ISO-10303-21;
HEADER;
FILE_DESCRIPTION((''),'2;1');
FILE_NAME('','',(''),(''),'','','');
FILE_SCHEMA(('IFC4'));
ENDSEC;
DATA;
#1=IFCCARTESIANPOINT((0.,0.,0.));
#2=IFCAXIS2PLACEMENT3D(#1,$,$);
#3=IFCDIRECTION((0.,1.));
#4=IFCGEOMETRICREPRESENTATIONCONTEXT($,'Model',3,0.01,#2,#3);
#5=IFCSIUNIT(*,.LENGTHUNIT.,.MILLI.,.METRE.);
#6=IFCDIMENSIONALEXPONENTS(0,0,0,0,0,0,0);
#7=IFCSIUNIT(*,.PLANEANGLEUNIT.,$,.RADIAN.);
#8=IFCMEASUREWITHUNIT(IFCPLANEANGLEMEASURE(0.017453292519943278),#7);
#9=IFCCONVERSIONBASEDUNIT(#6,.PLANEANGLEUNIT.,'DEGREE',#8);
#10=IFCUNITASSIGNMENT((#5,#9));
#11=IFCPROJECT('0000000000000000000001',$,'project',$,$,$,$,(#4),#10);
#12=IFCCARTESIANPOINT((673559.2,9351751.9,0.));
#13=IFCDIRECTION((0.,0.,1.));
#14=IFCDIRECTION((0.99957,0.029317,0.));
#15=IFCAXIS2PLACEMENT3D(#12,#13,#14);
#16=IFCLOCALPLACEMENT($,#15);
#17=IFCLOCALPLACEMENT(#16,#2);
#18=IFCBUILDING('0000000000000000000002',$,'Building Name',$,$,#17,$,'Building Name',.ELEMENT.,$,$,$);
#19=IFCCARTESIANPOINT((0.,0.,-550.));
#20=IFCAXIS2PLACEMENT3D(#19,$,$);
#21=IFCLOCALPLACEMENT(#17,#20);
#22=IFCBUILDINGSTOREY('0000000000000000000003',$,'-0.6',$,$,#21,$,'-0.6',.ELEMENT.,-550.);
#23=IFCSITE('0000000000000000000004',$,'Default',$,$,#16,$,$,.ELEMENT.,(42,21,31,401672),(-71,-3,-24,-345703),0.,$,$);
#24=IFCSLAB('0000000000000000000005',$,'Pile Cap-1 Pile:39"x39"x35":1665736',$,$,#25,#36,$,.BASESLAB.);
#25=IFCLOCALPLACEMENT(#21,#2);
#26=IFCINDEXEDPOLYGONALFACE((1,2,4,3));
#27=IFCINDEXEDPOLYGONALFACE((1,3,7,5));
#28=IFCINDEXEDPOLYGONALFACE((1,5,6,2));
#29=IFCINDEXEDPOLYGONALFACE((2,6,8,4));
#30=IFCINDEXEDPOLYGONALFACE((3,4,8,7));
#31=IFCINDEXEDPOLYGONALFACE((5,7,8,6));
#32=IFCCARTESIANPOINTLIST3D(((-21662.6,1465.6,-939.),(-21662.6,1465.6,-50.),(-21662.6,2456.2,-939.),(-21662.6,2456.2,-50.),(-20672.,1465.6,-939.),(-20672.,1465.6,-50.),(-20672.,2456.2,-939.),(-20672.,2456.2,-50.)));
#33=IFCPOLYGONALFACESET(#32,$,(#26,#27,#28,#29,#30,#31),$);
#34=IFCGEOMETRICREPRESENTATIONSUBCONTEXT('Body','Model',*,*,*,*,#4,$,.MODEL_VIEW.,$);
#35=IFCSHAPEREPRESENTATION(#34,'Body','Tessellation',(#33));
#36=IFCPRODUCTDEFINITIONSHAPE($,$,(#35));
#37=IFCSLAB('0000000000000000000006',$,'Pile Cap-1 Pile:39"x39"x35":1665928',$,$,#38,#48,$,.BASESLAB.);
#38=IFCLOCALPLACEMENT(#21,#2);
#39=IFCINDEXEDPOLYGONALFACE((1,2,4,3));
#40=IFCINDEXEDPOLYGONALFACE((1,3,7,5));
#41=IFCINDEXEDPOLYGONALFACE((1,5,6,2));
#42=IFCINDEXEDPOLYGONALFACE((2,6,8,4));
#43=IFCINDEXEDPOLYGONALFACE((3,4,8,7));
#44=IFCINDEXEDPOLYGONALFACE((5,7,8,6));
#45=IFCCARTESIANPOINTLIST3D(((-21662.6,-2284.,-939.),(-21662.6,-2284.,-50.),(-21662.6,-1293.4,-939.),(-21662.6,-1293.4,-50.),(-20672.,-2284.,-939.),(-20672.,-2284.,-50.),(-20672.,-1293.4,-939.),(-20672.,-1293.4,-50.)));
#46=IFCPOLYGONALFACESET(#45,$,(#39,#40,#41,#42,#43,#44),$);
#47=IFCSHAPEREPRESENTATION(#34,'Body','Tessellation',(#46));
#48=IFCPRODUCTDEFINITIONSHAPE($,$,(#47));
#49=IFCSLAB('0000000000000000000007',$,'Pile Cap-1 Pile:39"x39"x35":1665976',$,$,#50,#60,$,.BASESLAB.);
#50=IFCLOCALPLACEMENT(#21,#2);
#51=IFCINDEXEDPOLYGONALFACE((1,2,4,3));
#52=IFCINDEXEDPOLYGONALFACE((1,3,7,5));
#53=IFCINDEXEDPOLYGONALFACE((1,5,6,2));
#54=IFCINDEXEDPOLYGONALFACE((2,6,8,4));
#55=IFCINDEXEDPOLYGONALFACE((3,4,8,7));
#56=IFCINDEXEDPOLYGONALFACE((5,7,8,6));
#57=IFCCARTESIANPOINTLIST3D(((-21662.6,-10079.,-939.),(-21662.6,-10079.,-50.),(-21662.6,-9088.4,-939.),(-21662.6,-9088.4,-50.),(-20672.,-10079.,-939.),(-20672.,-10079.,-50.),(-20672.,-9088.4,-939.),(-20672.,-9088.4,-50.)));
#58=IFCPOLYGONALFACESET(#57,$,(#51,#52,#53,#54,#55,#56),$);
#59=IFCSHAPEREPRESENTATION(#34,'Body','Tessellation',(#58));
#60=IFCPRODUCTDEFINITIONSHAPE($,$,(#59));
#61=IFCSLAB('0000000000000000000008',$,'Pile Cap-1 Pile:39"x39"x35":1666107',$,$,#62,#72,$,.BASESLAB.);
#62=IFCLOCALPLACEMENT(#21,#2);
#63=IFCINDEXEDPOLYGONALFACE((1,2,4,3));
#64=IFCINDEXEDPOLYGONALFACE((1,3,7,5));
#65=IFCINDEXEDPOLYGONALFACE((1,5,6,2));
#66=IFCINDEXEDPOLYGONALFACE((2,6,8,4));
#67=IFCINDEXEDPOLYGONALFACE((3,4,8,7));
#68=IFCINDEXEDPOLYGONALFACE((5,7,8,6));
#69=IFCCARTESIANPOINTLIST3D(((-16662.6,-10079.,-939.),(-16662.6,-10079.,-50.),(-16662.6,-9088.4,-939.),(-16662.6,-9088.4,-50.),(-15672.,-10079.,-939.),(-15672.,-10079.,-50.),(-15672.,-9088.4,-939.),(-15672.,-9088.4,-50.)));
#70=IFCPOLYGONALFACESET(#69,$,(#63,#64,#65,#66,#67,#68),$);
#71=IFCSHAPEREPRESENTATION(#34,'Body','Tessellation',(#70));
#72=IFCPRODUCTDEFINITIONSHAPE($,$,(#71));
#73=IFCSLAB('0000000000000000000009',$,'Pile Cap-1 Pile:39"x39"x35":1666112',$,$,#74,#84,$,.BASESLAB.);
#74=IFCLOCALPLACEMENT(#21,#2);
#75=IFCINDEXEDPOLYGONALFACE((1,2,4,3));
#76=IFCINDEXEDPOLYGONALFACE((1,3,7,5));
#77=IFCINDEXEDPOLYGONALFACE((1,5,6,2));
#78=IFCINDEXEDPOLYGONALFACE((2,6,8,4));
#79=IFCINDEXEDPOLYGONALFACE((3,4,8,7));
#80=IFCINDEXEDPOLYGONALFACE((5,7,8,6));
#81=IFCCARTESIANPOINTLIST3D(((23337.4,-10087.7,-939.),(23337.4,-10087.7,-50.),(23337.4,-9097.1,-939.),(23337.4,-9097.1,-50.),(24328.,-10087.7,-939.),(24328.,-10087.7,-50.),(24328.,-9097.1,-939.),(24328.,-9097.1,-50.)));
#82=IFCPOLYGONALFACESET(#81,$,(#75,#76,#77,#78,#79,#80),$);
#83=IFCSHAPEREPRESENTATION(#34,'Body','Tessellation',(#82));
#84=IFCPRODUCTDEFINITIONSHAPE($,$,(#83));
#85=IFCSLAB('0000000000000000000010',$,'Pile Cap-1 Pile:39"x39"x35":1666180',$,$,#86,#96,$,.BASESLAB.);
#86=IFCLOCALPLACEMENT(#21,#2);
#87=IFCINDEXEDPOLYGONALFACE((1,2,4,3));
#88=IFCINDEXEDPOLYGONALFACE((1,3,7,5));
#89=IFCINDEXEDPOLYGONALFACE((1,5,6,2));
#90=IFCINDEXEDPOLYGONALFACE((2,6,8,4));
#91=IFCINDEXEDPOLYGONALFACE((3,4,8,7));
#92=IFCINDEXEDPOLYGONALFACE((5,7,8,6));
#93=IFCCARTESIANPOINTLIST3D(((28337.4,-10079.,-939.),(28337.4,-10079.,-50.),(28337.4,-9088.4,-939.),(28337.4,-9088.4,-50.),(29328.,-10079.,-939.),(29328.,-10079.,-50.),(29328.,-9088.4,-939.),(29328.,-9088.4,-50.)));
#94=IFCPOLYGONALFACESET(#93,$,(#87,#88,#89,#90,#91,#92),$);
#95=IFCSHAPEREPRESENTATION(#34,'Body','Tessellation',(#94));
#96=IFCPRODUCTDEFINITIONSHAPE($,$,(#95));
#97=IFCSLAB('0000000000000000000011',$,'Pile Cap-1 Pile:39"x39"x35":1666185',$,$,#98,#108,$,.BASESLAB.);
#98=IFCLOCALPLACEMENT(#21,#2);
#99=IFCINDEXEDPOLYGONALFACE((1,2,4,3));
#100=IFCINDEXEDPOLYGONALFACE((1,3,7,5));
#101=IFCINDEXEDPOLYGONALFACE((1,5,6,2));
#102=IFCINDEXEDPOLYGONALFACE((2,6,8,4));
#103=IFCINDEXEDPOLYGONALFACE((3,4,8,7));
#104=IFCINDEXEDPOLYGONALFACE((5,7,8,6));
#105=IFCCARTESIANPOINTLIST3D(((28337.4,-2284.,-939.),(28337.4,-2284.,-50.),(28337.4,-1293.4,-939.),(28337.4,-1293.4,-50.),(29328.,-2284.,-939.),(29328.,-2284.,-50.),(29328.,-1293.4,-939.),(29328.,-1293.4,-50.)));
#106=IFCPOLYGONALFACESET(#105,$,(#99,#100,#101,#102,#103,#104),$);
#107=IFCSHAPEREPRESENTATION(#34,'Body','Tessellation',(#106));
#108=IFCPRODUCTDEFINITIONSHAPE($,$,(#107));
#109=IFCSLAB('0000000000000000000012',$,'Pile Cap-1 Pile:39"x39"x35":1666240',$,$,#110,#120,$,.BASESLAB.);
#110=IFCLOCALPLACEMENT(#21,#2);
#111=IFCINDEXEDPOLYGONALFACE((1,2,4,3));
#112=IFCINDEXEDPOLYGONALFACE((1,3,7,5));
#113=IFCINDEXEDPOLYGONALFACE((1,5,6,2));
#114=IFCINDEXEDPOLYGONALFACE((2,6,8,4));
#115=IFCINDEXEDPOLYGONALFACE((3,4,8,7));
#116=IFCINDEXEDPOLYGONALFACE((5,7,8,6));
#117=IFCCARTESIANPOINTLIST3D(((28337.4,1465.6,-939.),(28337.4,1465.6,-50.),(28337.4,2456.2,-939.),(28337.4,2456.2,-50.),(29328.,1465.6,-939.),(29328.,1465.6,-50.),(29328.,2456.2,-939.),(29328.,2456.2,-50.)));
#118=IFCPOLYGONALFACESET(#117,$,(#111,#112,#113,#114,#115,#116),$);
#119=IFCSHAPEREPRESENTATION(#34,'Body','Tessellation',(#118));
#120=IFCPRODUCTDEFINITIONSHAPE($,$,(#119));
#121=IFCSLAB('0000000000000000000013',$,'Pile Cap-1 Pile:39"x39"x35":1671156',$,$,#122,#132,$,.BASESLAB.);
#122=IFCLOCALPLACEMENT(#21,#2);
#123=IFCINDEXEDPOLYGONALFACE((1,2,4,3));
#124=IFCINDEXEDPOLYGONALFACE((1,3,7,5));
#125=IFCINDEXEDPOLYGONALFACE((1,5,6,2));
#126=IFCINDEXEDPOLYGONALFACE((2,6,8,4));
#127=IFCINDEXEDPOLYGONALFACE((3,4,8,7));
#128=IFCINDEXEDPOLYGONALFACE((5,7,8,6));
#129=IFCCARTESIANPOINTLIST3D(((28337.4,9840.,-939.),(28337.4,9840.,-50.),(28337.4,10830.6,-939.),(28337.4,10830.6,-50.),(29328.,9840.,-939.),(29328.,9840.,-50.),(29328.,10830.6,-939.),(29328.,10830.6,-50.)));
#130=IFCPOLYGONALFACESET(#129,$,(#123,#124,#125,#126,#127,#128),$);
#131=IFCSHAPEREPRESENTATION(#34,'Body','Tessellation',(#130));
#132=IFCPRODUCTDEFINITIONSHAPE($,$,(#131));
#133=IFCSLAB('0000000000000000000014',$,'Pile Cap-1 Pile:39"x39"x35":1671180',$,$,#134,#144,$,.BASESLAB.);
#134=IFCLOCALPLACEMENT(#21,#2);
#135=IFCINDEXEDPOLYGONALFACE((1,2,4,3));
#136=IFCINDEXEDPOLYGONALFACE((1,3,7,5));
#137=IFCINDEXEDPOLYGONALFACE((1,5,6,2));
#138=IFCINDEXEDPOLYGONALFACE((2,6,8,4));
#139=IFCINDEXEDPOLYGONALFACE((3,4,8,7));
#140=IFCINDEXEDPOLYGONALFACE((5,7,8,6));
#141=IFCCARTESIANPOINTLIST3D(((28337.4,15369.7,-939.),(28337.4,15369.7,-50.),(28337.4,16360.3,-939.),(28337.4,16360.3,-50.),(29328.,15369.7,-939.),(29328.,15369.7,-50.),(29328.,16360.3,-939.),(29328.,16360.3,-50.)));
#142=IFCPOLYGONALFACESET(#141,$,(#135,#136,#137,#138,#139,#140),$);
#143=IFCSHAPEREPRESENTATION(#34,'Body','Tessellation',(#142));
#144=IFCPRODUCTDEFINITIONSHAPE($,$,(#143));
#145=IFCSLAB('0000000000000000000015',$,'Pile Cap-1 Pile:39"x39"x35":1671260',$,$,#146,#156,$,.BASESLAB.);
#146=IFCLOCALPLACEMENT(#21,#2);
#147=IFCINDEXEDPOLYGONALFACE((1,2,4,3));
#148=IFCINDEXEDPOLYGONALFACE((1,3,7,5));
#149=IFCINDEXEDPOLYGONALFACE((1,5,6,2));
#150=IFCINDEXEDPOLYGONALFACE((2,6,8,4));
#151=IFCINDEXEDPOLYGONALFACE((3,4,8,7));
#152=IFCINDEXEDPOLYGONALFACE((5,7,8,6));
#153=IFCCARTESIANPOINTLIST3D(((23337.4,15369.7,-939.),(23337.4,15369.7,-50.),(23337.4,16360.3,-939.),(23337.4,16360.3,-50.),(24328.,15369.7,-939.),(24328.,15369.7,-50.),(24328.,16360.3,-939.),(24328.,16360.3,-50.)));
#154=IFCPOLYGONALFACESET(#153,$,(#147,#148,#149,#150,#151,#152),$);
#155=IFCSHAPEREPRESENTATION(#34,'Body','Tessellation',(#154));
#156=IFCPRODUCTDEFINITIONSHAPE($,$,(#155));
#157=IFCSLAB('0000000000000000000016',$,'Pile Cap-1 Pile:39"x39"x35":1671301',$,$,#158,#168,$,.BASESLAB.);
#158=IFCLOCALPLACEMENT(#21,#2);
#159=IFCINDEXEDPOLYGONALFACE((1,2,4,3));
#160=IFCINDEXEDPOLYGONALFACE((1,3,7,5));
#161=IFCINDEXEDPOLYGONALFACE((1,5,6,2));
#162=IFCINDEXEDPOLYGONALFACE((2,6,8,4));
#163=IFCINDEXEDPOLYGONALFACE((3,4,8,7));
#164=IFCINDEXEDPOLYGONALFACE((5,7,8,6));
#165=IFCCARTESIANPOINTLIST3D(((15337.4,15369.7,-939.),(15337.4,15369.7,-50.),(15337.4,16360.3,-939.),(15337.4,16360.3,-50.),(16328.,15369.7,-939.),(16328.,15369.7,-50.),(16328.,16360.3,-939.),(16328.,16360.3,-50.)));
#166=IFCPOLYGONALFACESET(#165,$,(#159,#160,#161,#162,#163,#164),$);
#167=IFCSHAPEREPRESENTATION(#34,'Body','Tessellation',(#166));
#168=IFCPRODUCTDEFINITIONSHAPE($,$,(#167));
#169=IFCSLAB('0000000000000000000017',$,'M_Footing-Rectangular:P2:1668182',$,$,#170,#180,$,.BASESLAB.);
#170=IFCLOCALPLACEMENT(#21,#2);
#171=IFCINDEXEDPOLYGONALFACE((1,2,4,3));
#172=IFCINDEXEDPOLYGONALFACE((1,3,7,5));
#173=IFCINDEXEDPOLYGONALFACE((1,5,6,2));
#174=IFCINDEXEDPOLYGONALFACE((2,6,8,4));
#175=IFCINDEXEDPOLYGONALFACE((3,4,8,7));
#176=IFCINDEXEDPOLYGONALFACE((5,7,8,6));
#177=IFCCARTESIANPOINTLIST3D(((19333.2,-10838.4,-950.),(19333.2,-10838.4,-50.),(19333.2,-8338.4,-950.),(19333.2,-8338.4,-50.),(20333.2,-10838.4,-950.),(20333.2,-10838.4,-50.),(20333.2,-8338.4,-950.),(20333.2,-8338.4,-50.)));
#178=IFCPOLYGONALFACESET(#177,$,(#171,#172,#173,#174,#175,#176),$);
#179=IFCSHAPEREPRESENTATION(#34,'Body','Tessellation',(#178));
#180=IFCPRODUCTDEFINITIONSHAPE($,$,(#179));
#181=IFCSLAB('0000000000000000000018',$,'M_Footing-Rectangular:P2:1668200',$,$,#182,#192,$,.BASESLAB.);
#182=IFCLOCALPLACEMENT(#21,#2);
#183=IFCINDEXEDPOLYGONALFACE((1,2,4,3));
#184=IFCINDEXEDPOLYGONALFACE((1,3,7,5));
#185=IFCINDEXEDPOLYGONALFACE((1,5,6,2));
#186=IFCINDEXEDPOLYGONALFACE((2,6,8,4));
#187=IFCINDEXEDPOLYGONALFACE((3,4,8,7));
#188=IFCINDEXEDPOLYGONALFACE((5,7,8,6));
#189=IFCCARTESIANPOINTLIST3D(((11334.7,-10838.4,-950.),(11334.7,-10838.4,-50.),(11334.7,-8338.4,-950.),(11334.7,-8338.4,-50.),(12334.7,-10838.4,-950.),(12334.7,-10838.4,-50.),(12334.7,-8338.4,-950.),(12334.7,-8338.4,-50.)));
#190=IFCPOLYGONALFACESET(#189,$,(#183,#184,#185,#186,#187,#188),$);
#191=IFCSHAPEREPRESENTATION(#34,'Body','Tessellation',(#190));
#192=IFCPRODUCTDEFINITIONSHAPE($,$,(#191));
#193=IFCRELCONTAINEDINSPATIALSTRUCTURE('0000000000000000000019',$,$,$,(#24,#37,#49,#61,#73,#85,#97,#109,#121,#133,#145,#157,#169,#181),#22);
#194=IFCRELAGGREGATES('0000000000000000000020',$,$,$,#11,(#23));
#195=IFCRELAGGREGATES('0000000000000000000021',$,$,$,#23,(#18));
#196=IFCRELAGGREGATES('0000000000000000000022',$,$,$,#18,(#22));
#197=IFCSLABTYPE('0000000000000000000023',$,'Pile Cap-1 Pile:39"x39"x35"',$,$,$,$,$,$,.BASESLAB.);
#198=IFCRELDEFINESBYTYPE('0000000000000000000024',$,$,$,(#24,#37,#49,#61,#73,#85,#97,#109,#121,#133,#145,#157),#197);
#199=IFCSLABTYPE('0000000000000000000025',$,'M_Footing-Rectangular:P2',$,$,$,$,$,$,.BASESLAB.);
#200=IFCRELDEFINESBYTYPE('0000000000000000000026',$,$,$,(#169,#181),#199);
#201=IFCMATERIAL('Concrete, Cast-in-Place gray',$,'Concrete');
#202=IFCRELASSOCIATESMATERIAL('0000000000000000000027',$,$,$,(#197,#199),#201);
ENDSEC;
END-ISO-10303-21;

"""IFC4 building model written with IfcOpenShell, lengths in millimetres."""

from ifc_helpers import new_model, entity, si_unit, converted_unit, direction, frame, origin, place, context, subcontext, project, spatial, indexed_curve, outline, extrude, material, type_object, element, save


model = new_model("IFC4")

# Units and contexts
model_context = context("Model", 3, precision=0.01, world=origin(), true_north=direction((0.0, 1.0)))
body_context = subcontext(model_context, "Body", "Model", "MODEL_VIEW")
ifc_project = project(units=[si_unit("LENGTHUNIT", "METRE", prefix="MILLI"), converted_unit("PLANEANGLEUNIT", "DEGREE", entity("IfcPlaneAngleMeasure", 0.017453292519943278), si_unit("PLANEANGLEUNIT", "RADIAN"), dimensions=[0, 0, 0, 0, 0, 0, 0])], contexts=[model_context])

# Site, building, storey
site_placement = place(None, frame((673559.2, 9351751.9, 0.0), z_axis=(0.0, 0.0, 1.0), x_axis=(0.99957, 0.029317, 0.0)))
site = spatial("IfcSite", under=ifc_project, at=site_placement, Name="Default", CompositionType="ELEMENT", RefLatitude=(42, 21, 31, 401672), RefLongitude=(-71, -3, -24, -345703), RefElevation=0.0)
building_placement = place(site_placement, origin())
building = spatial("IfcBuilding", under=site, at=building_placement, Name="Building Name", LongName="Building Name", CompositionType="ELEMENT")
storey_placement = place(building_placement, frame((0.0, 0.0, -550.0)))
storey = spatial("IfcBuildingStorey", under=building, at=storey_placement, Name="-0.6", LongName="-0.6", CompositionType="ELEMENT", Elevation=-550.0)

# Shared definitions
ifc_material = material(Name="Concrete, Cast-in-Place gray", Category="Concrete")

# Slabs
slab_type_1 = type_object("IfcSlabType", Name="Pile Cap-1 Pile:39\"x39\"x35\"", PredefinedType="BASESLAB", material=ifc_material)
slab_1_placement = place(storey_placement, origin())
element("IfcSlab", 1, at=slab_1_placement, inside=storey, type_object=slab_type_1, Name="Pile Cap-1 Pile:39\"x39\"x35\":1665736", PredefinedType="BASESLAB", context=body_context, shape_type="SweptSolid", body=[
    extrude(outline(indexed_curve([(-495.3, -495.3), (495.3, -495.3), (495.3, 495.3), (-495.3, 495.3), (-495.3, -495.3)], self_intersect=False)), frame((-21167.3, 1960.9, -939.0)), (0.0, 0.0, 1.0), 889.0),
])
slab_2_placement = place(storey_placement, origin())
element("IfcSlab", 2, at=slab_2_placement, inside=storey, type_object=slab_type_1, Name="Pile Cap-1 Pile:39\"x39\"x35\":1665928", PredefinedType="BASESLAB", context=body_context, shape_type="SweptSolid", body=[
    extrude(outline(indexed_curve([(-495.3, -495.3), (495.3, -495.3), (495.3, 495.3), (-495.3, 495.3), (-495.3, -495.3)], self_intersect=False)), frame((-21167.3, -1788.7, -939.0)), (0.0, 0.0, 1.0), 889.0),
])
slab_3_placement = place(storey_placement, origin())
element("IfcSlab", 3, at=slab_3_placement, inside=storey, type_object=slab_type_1, Name="Pile Cap-1 Pile:39\"x39\"x35\":1665976", PredefinedType="BASESLAB", context=body_context, shape_type="SweptSolid", body=[
    extrude(outline(indexed_curve([(-495.3, -495.3), (495.3, -495.3), (495.3, 495.3), (-495.3, 495.3), (-495.3, -495.3)], self_intersect=False)), frame((-21167.3, -9583.7, -939.0)), (0.0, 0.0, 1.0), 889.0),
])
slab_4_placement = place(storey_placement, origin())
element("IfcSlab", 4, at=slab_4_placement, inside=storey, type_object=slab_type_1, Name="Pile Cap-1 Pile:39\"x39\"x35\":1666107", PredefinedType="BASESLAB", context=body_context, shape_type="SweptSolid", body=[
    extrude(outline(indexed_curve([(-495.3, -495.3), (495.3, -495.3), (495.3, 495.3), (-495.3, 495.3), (-495.3, -495.3)], self_intersect=False)), frame((-16167.3, -9583.7, -939.0)), (0.0, 0.0, 1.0), 889.0),
])
slab_5_placement = place(storey_placement, origin())
element("IfcSlab", 5, at=slab_5_placement, inside=storey, type_object=slab_type_1, Name="Pile Cap-1 Pile:39\"x39\"x35\":1666112", PredefinedType="BASESLAB", context=body_context, shape_type="SweptSolid", body=[
    extrude(outline(indexed_curve([(-495.3, -495.3), (495.3, -495.3), (495.3, 495.3), (-495.3, 495.3), (-495.3, -495.3)], self_intersect=False)), frame((23832.7, -9592.4, -939.0)), (0.0, 0.0, 1.0), 889.0),
])
slab_6_placement = place(storey_placement, origin())
element("IfcSlab", 6, at=slab_6_placement, inside=storey, type_object=slab_type_1, Name="Pile Cap-1 Pile:39\"x39\"x35\":1666180", PredefinedType="BASESLAB", context=body_context, shape_type="SweptSolid", body=[
    extrude(outline(indexed_curve([(-495.3, -495.3), (495.3, -495.3), (495.3, 495.3), (-495.3, 495.3), (-495.3, -495.3)], self_intersect=False)), frame((28832.7, -9583.7, -939.0)), (0.0, 0.0, 1.0), 889.0),
])
slab_7_placement = place(storey_placement, origin())
element("IfcSlab", 7, at=slab_7_placement, inside=storey, type_object=slab_type_1, Name="Pile Cap-1 Pile:39\"x39\"x35\":1666185", PredefinedType="BASESLAB", context=body_context, shape_type="SweptSolid", body=[
    extrude(outline(indexed_curve([(-495.3, -495.3), (495.3, -495.3), (495.3, 495.3), (-495.3, 495.3), (-495.3, -495.3)], self_intersect=False)), frame((28832.7, -1788.7, -939.0)), (0.0, 0.0, 1.0), 889.0),
])
slab_8_placement = place(storey_placement, origin())
element("IfcSlab", 8, at=slab_8_placement, inside=storey, type_object=slab_type_1, Name="Pile Cap-1 Pile:39\"x39\"x35\":1666240", PredefinedType="BASESLAB", context=body_context, shape_type="SweptSolid", body=[
    extrude(outline(indexed_curve([(-495.3, -495.3), (495.3, -495.3), (495.3, 495.3), (-495.3, 495.3), (-495.3, -495.3)], self_intersect=False)), frame((28832.7, 1960.9, -939.0)), (0.0, 0.0, 1.0), 889.0),
])
slab_9_placement = place(storey_placement, origin())
element("IfcSlab", 9, at=slab_9_placement, inside=storey, type_object=slab_type_1, Name="Pile Cap-1 Pile:39\"x39\"x35\":1671156", PredefinedType="BASESLAB", context=body_context, shape_type="SweptSolid", body=[
    extrude(outline(indexed_curve([(-495.3, -495.3), (495.3, -495.3), (495.3, 495.3), (-495.3, 495.3), (-495.3, -495.3)], self_intersect=False)), frame((28832.7, 10335.3, -939.0)), (0.0, 0.0, 1.0), 889.0),
])
slab_10_placement = place(storey_placement, origin())
element("IfcSlab", 10, at=slab_10_placement, inside=storey, type_object=slab_type_1, Name="Pile Cap-1 Pile:39\"x39\"x35\":1671180", PredefinedType="BASESLAB", context=body_context, shape_type="SweptSolid", body=[
    extrude(outline(indexed_curve([(-495.3, -495.3), (495.3, -495.3), (495.3, 495.3), (-495.3, 495.3), (-495.3, -495.3)], self_intersect=False)), frame((28832.7, 15865.0, -939.0)), (0.0, 0.0, 1.0), 889.0),
])
slab_11_placement = place(storey_placement, origin())
element("IfcSlab", 11, at=slab_11_placement, inside=storey, type_object=slab_type_1, Name="Pile Cap-1 Pile:39\"x39\"x35\":1671260", PredefinedType="BASESLAB", context=body_context, shape_type="SweptSolid", body=[
    extrude(outline(indexed_curve([(-495.3, -495.3), (495.3, -495.3), (495.3, 495.3), (-495.3, 495.3), (-495.3, -495.3)], self_intersect=False)), frame((23832.7, 15865.0, -939.0)), (0.0, 0.0, 1.0), 889.0),
])
slab_12_placement = place(storey_placement, origin())
element("IfcSlab", 12, at=slab_12_placement, inside=storey, type_object=slab_type_1, Name="Pile Cap-1 Pile:39\"x39\"x35\":1671301", PredefinedType="BASESLAB", context=body_context, shape_type="SweptSolid", body=[
    extrude(outline(indexed_curve([(-495.3, -495.3), (495.3, -495.3), (495.3, 495.3), (-495.3, 495.3), (-495.3, -495.3)], self_intersect=False)), frame((15832.7, 15865.0, -939.0)), (0.0, 0.0, 1.0), 889.0),
])
slab_type_2 = type_object("IfcSlabType", Name="M_Footing-Rectangular:P2", PredefinedType="BASESLAB", material=ifc_material)
slab_13_placement = place(storey_placement, origin())
element("IfcSlab", 13, at=slab_13_placement, inside=storey, type_object=slab_type_2, Name="M_Footing-Rectangular:P2:1668182", PredefinedType="BASESLAB", context=body_context, shape_type="SweptSolid", body=[
    extrude(outline(indexed_curve([(-500.0, -1250.0), (500.0, -1250.0), (500.0, 1250.0), (-500.0, 1250.0), (-500.0, -1250.0)], self_intersect=False)), frame((19833.2, -9588.4, -950.0)), (0.0, 0.0, 1.0), 900.0),
])
slab_14_placement = place(storey_placement, origin())
element("IfcSlab", 14, at=slab_14_placement, inside=storey, type_object=slab_type_2, Name="M_Footing-Rectangular:P2:1668200", PredefinedType="BASESLAB", context=body_context, shape_type="SweptSolid", body=[
    extrude(outline(indexed_curve([(-500.0, -1250.0), (500.0, -1250.0), (500.0, 1250.0), (-500.0, 1250.0), (-500.0, -1250.0)], self_intersect=False)), frame((11834.7, -9588.4, -950.0)), (0.0, 0.0, 1.0), 900.0),
])

save(model, "model.ifc")
